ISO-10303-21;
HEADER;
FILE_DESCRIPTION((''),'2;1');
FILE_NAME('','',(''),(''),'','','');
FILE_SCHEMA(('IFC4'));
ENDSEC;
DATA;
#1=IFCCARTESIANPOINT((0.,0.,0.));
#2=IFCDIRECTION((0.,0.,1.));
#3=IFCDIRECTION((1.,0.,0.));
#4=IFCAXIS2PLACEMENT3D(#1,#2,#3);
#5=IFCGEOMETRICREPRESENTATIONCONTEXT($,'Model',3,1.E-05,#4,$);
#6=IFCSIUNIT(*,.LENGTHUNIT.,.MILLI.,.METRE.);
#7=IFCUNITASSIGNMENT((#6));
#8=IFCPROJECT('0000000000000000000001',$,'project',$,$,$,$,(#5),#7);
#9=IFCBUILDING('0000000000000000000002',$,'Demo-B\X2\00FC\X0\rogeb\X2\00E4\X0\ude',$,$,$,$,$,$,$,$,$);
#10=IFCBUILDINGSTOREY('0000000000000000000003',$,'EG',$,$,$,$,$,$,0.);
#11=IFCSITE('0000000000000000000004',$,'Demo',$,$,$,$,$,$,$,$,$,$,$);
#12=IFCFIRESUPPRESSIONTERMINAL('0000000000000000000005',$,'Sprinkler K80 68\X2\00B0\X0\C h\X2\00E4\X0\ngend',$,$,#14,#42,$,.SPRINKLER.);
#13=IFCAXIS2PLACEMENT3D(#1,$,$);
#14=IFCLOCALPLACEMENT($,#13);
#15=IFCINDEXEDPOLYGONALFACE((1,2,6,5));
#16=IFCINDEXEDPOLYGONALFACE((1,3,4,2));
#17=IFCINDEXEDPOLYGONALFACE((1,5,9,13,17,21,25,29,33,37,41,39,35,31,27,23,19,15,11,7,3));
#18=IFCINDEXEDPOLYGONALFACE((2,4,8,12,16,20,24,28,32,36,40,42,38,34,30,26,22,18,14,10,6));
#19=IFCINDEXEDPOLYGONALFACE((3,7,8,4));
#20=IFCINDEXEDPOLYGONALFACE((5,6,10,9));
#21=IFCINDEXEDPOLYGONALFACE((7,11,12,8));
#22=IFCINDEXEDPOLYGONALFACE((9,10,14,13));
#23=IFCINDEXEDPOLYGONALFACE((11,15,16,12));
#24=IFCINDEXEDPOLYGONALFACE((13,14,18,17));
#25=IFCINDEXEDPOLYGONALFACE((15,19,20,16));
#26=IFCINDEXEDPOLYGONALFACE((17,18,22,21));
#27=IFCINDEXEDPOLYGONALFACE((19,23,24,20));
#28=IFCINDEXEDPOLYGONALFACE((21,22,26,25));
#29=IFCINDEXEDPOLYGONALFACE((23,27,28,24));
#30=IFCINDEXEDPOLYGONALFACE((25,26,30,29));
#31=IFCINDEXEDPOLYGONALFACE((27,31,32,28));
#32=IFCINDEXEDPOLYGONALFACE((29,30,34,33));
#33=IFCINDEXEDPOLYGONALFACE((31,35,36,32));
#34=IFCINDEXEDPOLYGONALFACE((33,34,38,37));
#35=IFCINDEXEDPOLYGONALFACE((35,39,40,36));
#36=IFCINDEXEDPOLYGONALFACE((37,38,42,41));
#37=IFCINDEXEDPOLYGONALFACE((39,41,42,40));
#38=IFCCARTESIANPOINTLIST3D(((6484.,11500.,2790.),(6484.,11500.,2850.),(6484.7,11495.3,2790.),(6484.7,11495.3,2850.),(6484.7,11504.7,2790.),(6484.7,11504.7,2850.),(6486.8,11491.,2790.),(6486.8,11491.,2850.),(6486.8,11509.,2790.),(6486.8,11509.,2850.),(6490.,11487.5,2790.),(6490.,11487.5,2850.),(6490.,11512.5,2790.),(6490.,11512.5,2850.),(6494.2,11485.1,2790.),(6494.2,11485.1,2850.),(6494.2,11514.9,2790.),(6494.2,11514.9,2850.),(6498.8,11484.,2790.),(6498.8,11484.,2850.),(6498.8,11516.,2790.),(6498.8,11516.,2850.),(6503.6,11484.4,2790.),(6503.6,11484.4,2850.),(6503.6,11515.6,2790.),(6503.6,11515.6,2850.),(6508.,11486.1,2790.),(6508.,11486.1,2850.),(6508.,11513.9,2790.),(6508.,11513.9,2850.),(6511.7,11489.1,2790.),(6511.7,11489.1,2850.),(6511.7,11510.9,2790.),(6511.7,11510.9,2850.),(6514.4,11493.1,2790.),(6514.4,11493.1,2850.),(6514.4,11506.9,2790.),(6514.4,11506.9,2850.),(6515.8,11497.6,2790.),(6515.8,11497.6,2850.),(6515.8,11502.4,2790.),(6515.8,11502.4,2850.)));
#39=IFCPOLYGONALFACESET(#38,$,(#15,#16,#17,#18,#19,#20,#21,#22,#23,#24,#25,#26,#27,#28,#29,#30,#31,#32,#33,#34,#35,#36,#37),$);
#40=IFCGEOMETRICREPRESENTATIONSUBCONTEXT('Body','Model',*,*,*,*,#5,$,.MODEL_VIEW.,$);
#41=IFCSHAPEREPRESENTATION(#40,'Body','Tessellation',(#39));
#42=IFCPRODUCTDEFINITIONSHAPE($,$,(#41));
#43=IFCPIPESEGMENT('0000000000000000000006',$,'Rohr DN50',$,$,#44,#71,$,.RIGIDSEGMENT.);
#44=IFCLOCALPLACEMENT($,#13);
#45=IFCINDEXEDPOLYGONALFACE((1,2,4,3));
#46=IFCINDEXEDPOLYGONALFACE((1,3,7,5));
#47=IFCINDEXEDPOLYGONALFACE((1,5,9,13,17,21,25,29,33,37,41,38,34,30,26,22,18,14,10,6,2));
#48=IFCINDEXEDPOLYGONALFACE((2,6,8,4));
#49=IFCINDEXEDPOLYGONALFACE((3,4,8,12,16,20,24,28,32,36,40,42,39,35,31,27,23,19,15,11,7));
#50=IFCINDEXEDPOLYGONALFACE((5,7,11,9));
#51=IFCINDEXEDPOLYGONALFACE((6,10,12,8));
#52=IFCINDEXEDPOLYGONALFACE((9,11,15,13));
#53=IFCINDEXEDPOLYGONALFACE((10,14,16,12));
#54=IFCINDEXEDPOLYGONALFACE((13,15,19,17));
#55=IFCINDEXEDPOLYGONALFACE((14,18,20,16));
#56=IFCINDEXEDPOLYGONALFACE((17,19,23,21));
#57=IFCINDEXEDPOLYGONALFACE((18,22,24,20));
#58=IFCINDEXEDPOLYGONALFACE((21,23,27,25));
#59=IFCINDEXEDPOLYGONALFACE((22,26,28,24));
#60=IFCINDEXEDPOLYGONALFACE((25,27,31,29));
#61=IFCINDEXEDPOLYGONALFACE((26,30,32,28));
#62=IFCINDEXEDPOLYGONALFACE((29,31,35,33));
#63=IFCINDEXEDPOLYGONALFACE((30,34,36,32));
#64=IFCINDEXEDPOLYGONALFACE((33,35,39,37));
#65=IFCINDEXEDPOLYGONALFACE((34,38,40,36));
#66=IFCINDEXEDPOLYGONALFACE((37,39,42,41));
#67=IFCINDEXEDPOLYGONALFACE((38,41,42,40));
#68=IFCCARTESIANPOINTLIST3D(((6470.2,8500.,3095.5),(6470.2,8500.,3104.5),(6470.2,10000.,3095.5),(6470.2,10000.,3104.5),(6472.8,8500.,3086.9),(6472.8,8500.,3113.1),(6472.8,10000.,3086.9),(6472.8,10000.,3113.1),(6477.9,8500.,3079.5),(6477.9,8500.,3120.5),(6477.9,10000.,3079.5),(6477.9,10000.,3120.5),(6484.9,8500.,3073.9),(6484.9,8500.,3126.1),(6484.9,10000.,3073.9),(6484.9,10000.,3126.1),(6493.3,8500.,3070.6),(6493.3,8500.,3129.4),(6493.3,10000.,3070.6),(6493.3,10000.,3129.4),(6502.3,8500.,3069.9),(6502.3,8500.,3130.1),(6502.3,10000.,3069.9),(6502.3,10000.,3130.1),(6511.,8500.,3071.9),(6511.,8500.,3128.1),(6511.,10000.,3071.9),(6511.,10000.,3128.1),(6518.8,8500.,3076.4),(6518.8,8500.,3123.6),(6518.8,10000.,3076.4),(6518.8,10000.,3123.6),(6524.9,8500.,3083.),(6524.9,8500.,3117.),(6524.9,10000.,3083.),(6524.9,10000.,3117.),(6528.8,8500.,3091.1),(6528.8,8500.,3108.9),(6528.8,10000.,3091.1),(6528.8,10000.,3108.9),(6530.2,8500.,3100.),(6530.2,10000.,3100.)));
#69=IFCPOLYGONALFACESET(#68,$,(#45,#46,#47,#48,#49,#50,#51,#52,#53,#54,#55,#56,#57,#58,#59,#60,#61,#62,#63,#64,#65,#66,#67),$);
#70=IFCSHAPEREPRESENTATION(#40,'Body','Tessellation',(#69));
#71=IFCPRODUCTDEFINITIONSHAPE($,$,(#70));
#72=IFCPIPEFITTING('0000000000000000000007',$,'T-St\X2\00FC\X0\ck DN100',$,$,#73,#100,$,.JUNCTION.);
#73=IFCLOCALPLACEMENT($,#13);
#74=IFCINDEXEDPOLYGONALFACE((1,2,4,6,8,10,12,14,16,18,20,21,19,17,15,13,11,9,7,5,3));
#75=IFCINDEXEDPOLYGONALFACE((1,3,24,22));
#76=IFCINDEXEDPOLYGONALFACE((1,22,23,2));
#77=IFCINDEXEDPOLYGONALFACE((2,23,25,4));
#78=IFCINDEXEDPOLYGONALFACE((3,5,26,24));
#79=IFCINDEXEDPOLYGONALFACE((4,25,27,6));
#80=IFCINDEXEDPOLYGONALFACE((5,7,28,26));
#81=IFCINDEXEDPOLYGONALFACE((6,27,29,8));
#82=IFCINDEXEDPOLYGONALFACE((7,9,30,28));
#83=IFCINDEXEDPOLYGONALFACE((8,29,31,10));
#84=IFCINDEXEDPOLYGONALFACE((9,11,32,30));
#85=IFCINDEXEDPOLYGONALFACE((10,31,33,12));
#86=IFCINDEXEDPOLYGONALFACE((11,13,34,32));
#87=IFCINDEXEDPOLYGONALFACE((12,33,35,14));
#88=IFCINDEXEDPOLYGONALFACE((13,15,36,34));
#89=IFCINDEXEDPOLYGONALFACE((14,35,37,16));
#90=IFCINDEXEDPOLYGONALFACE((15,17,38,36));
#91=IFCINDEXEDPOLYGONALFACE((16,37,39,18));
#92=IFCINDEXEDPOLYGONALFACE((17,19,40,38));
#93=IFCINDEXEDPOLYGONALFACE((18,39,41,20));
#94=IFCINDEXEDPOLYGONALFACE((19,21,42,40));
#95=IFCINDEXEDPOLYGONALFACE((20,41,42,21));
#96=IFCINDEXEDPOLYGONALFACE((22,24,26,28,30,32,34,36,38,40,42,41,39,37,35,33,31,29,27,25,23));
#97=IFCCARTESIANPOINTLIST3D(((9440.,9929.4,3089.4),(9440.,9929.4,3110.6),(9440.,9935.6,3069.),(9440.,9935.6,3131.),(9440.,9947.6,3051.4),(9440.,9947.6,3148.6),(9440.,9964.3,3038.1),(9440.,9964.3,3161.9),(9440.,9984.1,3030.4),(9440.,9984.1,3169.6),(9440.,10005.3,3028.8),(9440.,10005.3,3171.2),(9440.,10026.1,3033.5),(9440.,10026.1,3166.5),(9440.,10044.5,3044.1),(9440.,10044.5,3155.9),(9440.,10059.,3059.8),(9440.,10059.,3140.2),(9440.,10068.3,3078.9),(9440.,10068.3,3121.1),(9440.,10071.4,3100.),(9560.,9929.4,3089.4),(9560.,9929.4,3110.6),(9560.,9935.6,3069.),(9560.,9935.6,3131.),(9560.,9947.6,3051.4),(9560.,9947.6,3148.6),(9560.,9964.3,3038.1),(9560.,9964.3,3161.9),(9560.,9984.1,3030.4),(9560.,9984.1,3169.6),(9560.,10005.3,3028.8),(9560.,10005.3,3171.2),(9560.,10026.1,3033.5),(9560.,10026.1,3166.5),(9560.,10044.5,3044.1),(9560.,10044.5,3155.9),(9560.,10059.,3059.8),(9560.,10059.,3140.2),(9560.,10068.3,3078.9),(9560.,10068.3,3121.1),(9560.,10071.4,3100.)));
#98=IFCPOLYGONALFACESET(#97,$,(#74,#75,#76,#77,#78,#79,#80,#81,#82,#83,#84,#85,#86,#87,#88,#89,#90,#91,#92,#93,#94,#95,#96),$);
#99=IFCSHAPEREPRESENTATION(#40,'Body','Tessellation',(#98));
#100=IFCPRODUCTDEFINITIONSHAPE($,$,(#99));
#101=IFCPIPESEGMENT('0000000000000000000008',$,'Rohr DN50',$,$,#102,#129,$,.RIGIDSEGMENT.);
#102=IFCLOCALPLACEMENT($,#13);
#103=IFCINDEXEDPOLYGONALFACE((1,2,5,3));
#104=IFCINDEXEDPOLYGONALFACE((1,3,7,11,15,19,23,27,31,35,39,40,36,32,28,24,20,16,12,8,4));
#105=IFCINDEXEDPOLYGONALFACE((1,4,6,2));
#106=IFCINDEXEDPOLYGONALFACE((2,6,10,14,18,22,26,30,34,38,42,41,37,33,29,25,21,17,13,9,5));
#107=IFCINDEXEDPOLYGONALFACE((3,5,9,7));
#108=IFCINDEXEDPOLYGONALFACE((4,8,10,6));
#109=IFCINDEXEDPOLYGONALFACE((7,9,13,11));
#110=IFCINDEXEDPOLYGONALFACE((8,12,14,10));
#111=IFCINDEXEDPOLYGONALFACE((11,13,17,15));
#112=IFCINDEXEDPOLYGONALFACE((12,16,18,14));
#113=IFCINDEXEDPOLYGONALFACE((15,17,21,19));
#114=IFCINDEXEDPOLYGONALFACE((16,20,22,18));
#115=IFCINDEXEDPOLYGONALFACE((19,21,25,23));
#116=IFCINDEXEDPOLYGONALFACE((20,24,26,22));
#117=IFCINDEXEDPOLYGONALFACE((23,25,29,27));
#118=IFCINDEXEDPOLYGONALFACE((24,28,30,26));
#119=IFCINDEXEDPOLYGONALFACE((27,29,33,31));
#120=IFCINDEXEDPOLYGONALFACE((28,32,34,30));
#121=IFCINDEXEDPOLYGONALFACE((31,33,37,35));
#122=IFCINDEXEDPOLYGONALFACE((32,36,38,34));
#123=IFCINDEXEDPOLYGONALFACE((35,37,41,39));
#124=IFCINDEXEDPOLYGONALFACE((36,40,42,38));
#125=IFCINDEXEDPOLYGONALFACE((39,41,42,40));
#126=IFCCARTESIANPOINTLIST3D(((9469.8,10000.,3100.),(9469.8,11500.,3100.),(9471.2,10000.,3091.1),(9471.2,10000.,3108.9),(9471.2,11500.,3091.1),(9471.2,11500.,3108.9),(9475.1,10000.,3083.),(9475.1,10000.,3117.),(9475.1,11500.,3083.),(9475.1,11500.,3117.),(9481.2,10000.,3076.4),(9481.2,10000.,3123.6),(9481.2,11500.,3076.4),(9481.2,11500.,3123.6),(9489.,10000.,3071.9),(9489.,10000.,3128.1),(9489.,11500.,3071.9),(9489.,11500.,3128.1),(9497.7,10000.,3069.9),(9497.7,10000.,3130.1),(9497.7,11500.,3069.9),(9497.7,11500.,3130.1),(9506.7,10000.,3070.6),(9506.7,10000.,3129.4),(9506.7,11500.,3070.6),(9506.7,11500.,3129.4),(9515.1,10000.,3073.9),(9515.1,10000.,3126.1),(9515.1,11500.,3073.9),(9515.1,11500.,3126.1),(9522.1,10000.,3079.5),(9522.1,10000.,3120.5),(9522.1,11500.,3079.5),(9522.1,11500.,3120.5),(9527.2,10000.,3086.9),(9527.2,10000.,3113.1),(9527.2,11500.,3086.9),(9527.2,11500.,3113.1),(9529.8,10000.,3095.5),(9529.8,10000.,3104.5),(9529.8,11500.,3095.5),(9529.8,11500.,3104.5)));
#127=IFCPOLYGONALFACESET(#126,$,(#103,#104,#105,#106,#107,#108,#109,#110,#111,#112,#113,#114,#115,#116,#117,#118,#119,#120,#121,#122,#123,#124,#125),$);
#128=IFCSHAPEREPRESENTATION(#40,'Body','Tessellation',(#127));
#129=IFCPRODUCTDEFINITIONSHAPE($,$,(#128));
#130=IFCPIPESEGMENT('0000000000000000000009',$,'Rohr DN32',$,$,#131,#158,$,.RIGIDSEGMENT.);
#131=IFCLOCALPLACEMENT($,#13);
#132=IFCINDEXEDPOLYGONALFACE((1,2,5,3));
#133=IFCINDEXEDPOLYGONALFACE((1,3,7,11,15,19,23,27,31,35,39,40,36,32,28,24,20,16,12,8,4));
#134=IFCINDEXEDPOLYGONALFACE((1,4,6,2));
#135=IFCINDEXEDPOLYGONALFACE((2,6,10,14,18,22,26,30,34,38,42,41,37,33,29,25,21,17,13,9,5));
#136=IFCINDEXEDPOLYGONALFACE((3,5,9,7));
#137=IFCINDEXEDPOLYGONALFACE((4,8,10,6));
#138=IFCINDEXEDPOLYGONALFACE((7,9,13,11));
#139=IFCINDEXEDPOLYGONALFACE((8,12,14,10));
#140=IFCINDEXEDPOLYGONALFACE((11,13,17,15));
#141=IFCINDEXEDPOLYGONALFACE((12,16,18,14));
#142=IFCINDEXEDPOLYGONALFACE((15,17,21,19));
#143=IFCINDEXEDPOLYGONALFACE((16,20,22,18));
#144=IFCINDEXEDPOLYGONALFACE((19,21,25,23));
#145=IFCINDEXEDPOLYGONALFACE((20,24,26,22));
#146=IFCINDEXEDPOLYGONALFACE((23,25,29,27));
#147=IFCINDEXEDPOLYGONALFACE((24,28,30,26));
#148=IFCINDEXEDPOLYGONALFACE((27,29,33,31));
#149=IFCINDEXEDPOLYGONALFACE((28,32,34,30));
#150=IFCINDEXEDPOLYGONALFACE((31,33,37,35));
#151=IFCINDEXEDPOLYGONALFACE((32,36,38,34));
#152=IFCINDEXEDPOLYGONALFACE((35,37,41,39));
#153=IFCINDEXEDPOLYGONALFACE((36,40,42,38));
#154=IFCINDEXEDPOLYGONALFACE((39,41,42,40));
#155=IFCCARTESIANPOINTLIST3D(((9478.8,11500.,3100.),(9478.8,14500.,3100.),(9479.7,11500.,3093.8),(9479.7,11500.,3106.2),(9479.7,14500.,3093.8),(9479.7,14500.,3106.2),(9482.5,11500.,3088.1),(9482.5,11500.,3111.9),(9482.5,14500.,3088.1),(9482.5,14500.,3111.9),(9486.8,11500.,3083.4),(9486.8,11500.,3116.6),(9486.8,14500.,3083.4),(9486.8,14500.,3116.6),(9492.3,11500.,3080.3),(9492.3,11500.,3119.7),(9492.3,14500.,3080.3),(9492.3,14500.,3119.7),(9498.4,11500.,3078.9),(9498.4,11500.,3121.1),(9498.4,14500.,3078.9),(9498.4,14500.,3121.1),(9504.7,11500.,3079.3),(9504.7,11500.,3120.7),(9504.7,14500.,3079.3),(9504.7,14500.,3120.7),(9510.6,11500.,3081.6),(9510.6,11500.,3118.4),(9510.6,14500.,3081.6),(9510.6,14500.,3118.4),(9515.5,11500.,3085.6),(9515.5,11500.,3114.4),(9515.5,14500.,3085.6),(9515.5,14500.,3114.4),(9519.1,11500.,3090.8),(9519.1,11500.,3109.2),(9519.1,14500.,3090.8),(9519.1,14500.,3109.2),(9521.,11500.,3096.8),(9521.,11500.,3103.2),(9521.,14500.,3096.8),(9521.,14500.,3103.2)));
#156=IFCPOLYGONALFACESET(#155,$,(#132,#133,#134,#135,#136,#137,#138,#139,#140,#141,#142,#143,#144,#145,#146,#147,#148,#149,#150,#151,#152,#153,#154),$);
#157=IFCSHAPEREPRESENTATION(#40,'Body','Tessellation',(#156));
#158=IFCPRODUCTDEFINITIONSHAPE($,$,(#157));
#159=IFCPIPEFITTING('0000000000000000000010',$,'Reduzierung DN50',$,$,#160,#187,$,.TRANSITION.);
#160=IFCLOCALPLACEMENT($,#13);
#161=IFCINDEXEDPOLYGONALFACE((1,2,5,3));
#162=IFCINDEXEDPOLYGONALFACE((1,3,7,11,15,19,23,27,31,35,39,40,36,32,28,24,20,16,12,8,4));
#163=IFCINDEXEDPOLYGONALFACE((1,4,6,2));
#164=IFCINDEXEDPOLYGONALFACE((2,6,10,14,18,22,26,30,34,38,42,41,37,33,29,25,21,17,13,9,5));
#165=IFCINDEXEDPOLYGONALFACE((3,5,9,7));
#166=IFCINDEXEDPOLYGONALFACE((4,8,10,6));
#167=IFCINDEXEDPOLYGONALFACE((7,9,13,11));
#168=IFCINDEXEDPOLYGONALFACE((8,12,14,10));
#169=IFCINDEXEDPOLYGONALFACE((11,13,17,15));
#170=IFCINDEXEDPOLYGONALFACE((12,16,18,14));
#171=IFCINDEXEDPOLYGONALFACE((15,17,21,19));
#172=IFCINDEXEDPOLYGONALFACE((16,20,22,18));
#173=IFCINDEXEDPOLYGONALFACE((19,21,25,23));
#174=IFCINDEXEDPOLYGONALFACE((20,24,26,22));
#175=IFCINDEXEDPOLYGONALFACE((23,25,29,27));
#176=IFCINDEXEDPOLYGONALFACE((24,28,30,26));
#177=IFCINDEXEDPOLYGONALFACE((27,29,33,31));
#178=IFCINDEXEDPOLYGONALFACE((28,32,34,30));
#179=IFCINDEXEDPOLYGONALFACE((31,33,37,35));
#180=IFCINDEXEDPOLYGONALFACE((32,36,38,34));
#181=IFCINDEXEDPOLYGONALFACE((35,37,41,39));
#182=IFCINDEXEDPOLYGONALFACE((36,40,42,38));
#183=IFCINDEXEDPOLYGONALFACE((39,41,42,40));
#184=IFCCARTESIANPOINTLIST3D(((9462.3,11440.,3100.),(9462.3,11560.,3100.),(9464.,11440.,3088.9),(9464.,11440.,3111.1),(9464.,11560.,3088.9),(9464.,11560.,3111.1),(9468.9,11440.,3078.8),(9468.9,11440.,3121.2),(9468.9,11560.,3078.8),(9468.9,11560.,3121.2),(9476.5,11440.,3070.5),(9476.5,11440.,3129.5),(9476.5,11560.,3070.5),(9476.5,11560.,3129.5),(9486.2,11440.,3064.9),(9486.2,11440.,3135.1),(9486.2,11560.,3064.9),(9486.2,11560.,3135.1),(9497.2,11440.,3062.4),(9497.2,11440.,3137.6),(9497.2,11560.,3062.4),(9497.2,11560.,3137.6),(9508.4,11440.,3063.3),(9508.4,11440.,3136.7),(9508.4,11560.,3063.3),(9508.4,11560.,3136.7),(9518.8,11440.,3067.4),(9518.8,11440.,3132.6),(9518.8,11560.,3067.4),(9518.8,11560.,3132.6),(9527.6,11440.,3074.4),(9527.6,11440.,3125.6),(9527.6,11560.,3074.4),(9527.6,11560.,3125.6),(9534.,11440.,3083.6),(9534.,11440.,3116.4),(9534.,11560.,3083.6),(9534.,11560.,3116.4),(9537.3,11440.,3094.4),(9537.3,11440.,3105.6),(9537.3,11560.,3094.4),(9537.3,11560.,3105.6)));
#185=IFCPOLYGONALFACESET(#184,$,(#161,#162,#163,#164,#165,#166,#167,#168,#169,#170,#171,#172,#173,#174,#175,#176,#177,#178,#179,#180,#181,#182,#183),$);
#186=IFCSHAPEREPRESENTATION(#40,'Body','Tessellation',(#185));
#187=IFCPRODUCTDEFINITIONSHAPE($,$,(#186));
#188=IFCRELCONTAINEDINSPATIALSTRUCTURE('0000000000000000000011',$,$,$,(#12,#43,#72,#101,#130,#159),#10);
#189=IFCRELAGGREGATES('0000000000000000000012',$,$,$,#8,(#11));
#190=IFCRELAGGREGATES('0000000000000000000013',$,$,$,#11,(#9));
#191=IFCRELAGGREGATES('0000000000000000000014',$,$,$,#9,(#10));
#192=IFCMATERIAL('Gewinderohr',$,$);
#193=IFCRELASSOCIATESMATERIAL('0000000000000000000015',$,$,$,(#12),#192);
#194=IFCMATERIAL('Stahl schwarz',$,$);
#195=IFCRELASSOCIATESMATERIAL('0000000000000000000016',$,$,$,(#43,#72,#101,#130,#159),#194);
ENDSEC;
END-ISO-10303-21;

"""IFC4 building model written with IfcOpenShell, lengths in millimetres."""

from ifc_helpers import new_model, si_unit, frame, origin_with_axes, place, context, subcontext, project, spatial, circle, extrude, material, element, save


model = new_model("IFC4")

# Units and contexts
model_context = context("Model", 3, precision=1e-05, world=origin_with_axes())
body_context = subcontext(model_context, "Body", "Model", "MODEL_VIEW")
ifc_project = project(units=[si_unit("LENGTHUNIT", "METRE", prefix="MILLI")], contexts=[model_context])

# Site, building, storey
site = spatial("IfcSite", under=ifc_project, Name="Demo")
building = spatial("IfcBuilding", under=site, Name="Demo-Bürogebäude")
storey = spatial("IfcBuildingStorey", under=building, Name="EG", Elevation=0.0)

# Shared definitions
ifc_material_1 = material(Name="Stahl schwarz")

# Shared definitions
ifc_material_2 = material(Name="Gewinderohr")

# Fire suppression terminal
fire_suppression_terminal_1_placement = place(None, frame((6500.0, 11500.0, 2850.0), z_axis=(0.0, 0.0, -1.0), x_axis=(-1.0, 0.0, 0.0)))
element("IfcFireSuppressionTerminal", 1, at=fire_suppression_terminal_1_placement, inside=storey, material=ifc_material_2, Name="Sprinkler K80 68°C hängend", PredefinedType="SPRINKLER", context=body_context, shape_type="SweptSolid", body=[
    extrude(circle(Radius=16.0), origin_with_axes(), (0.0, 0.0, 1.0), 60.0),
])

# Pipe segment
pipe_segment_1_placement = place(None, frame((6500.0, 10000.0, 3100.0), z_axis=(0.0, -1.0, 0.0), x_axis=(1.0, 0.0, 0.0)))
element("IfcPipeSegment", 2, at=pipe_segment_1_placement, inside=storey, material=ifc_material_1, Name="Rohr DN50", PredefinedType="RIGIDSEGMENT", context=body_context, shape_type="SweptSolid", body=[
    extrude(circle(Radius=30.1), origin_with_axes(), (0.0, 0.0, 1.0), 1500.0),
])

# Pipe fitting
pipe_fitting_1_placement = place(None, frame((9440.0, 10000.0, 3100.0), z_axis=(1.0, 0.0, 0.0), x_axis=(0.0, 1.0, 0.0)))
element("IfcPipeFitting", 3, at=pipe_fitting_1_placement, inside=storey, material=ifc_material_1, Name="T-Stück DN100", PredefinedType="JUNCTION", context=body_context, shape_type="SweptSolid", body=[
    extrude(circle(Radius=71.4), origin_with_axes(), (0.0, 0.0, 1.0), 120.0),
])

# Pipe segments
pipe_segment_2_placement = place(None, frame((9500.0, 10000.0, 3100.0), z_axis=(0.0, 1.0, 0.0), x_axis=(-1.0, 0.0, 0.0)))
element("IfcPipeSegment", 4, at=pipe_segment_2_placement, inside=storey, material=ifc_material_1, Name="Rohr DN50", PredefinedType="RIGIDSEGMENT", context=body_context, shape_type="SweptSolid", body=[
    extrude(circle(Radius=30.1), origin_with_axes(), (0.0, 0.0, 1.0), 1500.0),
])
pipe_segment_3_placement = place(None, frame((9500.0, 11500.0, 3100.0), z_axis=(0.0, 1.0, 0.0), x_axis=(-1.0, 0.0, 0.0)))
element("IfcPipeSegment", 5, at=pipe_segment_3_placement, inside=storey, material=ifc_material_1, Name="Rohr DN32", PredefinedType="RIGIDSEGMENT", context=body_context, shape_type="SweptSolid", body=[
    extrude(circle(Radius=21.2), origin_with_axes(), (0.0, 0.0, 1.0), 3000.0),
])

# Pipe fitting
pipe_fitting_2_placement = place(None, frame((9500.0, 11440.0, 3100.0), z_axis=(0.0, 1.0, 0.0), x_axis=(-1.0, 0.0, 0.0)))
element("IfcPipeFitting", 6, at=pipe_fitting_2_placement, inside=storey, material=ifc_material_1, Name="Reduzierung DN50", PredefinedType="TRANSITION", context=body_context, shape_type="SweptSolid", body=[
    extrude(circle(Radius=37.7), origin_with_axes(), (0.0, 0.0, 1.0), 120.0),
])

save(model, "model.ifc")
